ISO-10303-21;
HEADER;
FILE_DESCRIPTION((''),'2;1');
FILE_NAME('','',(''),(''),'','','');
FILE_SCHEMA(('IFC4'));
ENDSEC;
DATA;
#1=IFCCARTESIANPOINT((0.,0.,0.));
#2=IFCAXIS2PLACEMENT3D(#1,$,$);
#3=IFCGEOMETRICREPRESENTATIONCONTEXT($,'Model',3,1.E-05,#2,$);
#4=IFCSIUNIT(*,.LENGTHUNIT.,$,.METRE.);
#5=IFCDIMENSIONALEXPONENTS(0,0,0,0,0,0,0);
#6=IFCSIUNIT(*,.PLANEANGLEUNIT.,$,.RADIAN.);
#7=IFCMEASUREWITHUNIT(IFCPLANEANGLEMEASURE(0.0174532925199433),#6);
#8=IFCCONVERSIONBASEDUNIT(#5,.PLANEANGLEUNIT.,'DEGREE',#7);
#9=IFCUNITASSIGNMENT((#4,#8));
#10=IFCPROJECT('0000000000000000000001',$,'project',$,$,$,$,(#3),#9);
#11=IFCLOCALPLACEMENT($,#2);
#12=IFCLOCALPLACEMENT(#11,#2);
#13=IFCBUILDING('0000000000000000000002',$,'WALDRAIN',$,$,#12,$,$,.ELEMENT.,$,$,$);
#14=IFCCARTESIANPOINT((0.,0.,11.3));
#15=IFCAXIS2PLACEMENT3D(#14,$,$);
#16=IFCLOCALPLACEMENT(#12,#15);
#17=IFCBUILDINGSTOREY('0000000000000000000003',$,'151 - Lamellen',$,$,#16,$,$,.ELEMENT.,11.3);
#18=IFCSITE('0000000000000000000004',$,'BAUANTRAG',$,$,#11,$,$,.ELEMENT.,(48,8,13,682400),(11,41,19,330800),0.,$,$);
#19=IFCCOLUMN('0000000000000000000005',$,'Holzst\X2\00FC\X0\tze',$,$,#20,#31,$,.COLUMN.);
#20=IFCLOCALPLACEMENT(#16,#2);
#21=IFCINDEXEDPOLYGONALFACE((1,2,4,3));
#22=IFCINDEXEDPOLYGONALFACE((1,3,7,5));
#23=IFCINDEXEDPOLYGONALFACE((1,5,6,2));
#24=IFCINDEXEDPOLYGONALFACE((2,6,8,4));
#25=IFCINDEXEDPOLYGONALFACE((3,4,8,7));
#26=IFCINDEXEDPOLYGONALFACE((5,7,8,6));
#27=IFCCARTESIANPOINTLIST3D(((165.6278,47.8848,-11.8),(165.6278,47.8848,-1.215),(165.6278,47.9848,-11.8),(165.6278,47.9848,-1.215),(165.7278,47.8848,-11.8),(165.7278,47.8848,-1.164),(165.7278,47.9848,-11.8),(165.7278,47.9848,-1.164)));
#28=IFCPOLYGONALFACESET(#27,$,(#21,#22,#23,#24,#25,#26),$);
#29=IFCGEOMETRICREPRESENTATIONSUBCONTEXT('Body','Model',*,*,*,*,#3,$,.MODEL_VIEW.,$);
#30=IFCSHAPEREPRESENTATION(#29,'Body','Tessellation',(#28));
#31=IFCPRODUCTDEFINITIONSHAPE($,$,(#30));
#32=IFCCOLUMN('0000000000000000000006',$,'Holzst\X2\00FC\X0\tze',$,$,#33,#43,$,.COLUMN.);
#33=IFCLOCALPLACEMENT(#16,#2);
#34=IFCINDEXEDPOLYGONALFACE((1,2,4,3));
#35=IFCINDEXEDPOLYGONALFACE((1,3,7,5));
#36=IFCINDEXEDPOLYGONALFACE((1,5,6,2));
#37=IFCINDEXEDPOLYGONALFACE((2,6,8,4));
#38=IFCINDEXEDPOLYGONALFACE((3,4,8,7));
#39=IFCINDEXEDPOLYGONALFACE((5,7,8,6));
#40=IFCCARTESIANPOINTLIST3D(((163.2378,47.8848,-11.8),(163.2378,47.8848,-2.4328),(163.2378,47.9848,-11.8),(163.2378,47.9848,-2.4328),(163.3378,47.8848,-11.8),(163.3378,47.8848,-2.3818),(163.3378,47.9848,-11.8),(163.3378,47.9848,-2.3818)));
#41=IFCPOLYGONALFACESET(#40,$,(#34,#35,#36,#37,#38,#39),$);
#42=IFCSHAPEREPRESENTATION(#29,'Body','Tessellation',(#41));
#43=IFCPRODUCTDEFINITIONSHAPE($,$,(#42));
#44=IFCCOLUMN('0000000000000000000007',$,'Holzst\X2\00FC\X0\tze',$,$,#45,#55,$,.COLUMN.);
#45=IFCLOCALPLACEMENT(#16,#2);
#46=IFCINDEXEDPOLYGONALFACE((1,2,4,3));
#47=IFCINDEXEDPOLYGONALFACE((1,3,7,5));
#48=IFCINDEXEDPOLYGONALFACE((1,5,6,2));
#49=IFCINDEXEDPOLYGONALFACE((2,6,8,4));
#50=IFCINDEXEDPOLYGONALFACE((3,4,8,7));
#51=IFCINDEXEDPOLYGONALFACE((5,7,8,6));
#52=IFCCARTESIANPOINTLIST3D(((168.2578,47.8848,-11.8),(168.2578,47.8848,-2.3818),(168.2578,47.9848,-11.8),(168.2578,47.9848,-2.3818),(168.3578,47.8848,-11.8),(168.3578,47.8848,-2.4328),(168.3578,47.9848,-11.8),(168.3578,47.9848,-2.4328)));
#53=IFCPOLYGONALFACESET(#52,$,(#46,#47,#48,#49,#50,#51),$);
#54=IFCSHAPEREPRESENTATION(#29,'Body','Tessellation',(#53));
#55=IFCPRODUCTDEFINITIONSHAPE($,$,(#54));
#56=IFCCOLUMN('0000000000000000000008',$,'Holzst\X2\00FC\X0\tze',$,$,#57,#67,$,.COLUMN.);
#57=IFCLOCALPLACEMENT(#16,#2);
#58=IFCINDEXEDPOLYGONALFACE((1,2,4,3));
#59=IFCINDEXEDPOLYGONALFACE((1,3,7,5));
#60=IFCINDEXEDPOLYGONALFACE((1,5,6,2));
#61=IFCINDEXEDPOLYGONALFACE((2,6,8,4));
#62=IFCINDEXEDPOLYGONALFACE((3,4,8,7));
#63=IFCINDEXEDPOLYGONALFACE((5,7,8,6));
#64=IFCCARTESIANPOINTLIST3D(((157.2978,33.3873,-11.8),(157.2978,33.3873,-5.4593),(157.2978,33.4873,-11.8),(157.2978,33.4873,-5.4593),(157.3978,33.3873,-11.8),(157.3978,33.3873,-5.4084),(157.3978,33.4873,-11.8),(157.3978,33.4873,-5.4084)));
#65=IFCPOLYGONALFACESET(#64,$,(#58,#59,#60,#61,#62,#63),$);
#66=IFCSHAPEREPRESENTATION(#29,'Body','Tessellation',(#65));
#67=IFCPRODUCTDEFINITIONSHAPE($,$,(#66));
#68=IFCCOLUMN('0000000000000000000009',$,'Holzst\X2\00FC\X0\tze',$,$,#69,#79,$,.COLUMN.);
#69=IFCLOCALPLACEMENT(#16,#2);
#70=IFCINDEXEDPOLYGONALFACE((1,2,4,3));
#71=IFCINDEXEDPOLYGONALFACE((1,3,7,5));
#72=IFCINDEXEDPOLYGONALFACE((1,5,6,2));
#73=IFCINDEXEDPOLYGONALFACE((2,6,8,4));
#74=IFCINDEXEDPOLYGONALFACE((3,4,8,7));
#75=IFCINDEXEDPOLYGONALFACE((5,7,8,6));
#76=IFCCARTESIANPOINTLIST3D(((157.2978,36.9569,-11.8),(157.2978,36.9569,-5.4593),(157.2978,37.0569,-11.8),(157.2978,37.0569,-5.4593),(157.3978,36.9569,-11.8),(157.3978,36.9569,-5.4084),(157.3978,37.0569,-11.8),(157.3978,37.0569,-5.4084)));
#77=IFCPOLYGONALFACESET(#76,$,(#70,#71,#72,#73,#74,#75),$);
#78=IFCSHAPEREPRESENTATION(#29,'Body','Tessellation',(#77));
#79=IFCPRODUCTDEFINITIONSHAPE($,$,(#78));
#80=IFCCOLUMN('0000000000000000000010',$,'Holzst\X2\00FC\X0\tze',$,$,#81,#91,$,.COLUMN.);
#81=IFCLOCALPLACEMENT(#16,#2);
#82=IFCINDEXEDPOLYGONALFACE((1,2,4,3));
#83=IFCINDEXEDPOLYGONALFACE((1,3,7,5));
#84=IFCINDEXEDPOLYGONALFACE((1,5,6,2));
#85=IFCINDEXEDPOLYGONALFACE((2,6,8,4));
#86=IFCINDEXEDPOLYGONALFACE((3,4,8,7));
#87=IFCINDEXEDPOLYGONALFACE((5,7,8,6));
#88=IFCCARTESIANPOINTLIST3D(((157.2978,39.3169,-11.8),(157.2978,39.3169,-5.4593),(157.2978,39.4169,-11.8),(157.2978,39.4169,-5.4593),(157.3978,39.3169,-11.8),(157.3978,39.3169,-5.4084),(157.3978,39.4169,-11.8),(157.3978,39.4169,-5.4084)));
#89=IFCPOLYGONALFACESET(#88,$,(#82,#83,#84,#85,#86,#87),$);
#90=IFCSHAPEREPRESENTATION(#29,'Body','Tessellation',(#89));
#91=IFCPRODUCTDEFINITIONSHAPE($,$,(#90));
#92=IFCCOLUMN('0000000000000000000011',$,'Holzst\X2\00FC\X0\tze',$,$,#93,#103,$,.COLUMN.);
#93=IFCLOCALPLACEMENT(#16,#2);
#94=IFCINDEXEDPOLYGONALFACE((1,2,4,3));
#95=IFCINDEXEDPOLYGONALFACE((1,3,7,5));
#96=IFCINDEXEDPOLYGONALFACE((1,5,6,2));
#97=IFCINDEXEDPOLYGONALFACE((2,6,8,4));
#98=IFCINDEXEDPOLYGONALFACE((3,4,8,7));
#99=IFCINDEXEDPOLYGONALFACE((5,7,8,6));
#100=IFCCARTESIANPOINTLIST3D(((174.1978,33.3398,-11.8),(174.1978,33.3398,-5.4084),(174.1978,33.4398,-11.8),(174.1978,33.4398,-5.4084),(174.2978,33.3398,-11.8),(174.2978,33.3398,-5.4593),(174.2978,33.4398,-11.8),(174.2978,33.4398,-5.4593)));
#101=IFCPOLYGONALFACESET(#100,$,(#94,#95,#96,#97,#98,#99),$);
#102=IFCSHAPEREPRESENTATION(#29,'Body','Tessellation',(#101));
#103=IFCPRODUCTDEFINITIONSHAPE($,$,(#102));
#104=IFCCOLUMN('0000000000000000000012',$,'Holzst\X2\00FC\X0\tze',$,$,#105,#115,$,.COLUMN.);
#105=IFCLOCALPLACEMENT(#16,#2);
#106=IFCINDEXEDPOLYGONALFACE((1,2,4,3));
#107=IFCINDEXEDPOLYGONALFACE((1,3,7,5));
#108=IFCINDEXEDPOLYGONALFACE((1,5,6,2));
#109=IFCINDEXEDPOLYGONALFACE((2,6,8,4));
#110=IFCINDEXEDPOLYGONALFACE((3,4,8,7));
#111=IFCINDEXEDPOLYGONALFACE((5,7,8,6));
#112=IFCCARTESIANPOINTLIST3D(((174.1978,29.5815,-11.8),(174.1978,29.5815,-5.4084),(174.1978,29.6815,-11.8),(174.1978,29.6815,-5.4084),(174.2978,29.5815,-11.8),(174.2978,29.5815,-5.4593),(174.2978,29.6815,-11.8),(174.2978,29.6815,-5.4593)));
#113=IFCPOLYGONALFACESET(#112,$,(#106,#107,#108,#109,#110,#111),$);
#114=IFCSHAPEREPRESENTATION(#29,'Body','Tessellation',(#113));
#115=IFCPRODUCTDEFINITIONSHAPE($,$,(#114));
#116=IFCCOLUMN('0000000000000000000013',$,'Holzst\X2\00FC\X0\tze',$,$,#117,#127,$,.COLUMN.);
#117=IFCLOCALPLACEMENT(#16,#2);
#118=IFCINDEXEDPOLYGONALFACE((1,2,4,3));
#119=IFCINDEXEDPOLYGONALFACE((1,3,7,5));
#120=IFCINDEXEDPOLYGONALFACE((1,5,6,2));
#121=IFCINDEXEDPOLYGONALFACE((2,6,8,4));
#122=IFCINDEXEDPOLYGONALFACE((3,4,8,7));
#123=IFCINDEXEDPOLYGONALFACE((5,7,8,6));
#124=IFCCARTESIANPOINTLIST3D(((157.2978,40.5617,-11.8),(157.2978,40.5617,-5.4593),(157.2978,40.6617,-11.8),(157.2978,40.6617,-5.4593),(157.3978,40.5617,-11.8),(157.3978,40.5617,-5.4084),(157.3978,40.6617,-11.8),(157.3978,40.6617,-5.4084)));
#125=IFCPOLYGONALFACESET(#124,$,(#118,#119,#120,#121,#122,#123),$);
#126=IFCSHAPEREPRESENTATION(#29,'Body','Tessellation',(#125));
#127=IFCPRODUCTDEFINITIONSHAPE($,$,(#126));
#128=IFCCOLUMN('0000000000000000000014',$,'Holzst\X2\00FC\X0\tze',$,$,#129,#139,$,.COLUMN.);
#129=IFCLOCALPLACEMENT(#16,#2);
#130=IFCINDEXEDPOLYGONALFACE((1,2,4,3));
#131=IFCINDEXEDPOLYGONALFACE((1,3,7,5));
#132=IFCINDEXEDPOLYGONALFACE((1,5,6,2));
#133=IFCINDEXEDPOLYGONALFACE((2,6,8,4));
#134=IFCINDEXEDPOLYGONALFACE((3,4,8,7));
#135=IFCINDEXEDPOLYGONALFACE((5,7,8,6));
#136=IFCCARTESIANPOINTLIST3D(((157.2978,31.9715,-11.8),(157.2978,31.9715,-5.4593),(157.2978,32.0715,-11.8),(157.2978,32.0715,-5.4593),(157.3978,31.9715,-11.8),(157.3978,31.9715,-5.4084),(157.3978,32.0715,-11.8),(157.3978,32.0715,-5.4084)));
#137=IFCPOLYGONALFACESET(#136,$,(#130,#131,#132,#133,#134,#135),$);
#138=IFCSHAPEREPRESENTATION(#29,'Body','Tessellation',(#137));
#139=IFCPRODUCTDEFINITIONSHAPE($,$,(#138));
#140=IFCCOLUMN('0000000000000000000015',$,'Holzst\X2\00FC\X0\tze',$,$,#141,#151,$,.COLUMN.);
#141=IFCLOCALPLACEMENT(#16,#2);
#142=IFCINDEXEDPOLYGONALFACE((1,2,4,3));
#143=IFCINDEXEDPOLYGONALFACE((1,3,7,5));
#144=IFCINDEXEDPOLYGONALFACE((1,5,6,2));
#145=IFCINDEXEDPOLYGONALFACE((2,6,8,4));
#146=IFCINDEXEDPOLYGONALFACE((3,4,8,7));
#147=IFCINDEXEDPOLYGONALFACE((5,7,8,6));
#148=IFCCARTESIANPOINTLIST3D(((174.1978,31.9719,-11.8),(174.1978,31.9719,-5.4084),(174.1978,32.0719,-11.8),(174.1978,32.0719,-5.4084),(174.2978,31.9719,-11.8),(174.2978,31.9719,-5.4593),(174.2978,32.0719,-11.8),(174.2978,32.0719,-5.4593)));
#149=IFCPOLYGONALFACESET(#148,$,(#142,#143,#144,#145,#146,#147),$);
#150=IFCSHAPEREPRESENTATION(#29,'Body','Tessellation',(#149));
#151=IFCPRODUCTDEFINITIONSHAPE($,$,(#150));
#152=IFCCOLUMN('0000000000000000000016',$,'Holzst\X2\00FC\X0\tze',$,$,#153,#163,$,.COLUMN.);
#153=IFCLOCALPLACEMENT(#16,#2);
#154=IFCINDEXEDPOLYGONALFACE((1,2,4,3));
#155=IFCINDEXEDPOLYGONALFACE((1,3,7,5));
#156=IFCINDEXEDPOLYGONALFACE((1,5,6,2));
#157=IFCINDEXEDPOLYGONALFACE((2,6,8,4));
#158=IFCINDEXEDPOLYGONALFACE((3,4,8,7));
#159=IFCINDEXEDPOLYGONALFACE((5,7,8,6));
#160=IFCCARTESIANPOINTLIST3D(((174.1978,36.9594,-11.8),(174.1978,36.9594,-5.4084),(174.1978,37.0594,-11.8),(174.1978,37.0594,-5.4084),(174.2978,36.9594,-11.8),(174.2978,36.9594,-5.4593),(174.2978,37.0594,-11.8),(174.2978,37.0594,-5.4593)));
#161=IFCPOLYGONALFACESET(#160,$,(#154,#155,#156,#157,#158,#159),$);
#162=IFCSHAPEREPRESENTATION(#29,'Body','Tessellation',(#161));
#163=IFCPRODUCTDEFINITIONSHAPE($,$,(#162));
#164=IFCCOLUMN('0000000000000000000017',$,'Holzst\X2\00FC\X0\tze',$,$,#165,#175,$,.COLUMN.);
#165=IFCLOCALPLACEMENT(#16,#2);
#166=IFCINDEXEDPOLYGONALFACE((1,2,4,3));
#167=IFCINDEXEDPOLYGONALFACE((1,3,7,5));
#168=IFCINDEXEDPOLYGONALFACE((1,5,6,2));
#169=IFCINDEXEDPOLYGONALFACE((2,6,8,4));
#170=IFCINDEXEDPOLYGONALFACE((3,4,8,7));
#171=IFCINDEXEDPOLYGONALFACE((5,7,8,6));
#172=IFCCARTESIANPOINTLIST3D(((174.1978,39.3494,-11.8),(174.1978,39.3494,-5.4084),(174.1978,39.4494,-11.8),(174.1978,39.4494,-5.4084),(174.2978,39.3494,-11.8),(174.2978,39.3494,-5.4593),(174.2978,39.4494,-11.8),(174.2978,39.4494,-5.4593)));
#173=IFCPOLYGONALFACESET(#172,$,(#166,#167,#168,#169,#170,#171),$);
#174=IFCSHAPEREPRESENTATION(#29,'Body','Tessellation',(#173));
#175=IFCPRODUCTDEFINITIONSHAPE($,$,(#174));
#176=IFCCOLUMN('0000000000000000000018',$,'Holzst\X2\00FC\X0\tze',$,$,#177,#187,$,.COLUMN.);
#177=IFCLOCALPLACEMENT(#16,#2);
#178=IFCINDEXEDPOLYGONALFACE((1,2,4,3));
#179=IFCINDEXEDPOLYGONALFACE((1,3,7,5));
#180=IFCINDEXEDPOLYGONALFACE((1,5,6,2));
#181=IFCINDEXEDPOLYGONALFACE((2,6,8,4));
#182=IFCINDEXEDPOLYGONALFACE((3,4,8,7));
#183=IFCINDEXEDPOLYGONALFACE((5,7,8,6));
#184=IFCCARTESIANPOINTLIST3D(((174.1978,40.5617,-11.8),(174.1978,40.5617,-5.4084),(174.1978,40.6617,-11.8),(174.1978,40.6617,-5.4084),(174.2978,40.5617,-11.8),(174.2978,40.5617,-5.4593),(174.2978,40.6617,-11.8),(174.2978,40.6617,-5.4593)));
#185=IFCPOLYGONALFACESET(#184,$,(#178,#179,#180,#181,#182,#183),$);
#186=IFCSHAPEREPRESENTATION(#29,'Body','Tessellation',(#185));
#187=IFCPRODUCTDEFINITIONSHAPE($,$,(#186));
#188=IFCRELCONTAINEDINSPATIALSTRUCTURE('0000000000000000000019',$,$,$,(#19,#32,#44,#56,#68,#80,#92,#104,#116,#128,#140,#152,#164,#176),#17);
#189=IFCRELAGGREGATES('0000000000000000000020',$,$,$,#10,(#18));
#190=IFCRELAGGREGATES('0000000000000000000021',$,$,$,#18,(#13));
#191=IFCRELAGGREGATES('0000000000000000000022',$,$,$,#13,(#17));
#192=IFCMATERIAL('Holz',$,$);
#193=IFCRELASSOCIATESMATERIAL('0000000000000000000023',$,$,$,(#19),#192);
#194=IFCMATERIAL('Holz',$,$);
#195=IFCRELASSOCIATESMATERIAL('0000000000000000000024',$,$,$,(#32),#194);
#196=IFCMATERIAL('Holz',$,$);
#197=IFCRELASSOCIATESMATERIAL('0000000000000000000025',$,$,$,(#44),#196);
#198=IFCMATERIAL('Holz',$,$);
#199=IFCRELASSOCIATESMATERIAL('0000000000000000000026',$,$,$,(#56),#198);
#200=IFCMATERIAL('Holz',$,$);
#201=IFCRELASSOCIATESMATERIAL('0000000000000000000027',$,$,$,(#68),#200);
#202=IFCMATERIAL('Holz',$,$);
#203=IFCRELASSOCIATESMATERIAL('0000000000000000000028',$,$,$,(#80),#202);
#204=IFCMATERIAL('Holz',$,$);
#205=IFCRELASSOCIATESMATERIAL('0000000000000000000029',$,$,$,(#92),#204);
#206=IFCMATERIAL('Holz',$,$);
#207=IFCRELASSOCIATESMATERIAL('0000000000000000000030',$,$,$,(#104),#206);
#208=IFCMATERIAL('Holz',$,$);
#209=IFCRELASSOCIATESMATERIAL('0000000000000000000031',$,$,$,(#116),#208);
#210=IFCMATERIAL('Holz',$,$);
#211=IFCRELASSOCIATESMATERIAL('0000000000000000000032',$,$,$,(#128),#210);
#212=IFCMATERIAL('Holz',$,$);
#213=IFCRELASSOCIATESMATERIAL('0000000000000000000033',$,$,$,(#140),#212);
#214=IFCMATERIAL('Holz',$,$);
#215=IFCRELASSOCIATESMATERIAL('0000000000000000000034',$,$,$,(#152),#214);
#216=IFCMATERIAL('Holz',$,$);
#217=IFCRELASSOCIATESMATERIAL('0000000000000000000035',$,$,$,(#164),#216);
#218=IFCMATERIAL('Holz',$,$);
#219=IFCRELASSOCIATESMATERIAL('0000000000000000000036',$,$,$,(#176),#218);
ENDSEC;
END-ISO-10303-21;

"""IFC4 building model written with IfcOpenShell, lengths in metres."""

from ifc_helpers import new_model, entity, si_unit, converted_unit, frame, frame_2d, origin, origin_with_axes, place, context, subcontext, project, spatial, rectangle, extrude, clip, halfspace, material, element, save


model = new_model("IFC4")

# Units and contexts
model_context = context("Model", 3, precision=1e-05, world=origin())
body_context = subcontext(model_context, "Body", "Model", "MODEL_VIEW")
ifc_project = project(units=[si_unit("LENGTHUNIT", "METRE"), converted_unit("PLANEANGLEUNIT", "DEGREE", entity("IfcPlaneAngleMeasure", 0.0174532925199433), si_unit("PLANEANGLEUNIT", "RADIAN"), dimensions=[0, 0, 0, 0, 0, 0, 0])], contexts=[model_context])

# Site, building, storey
site_placement = place(None, origin())
site = spatial("IfcSite", under=ifc_project, at=site_placement, Name="BAUANTRAG", CompositionType="ELEMENT", RefLatitude=(48, 8, 13, 682400), RefLongitude=(11, 41, 19, 330800), RefElevation=0.0)
building_placement = place(site_placement, origin())
building = spatial("IfcBuilding", under=site, at=building_placement, Name="WALDRAIN", CompositionType="ELEMENT")
storey_placement = place(building_placement, frame((0.0, 0.0, 11.3)))
storey = spatial("IfcBuildingStorey", under=building, at=storey_placement, Name="151 - Lamellen", CompositionType="ELEMENT", Elevation=11.3)

# Columns
ifc_material_1 = material(Name="Holz")
column_1_placement = place(storey_placement, frame((165.7278, 47.8848, -11.8)))
element("IfcColumn", 1, at=column_1_placement, inside=storey, material=ifc_material_1, Name="Holzstütze", PredefinedType="COLUMN", context=body_context, shape_type="Clipping", body=[
    clip(extrude(rectangle(XDim=0.1, YDim=0.1, at=frame_2d((-0.05, 0.05), x_axis=(0.0, 1.0))), origin_with_axes(), (0.0, 0.0, 1.0), 10.636), halfspace(frame((-0.05, 0.05, 10.6105), z_axis=(0.45399, 0.0, -0.891007), x_axis=(0.0, 1.0, 0.0)), True)),
])
ifc_material_2 = material(Name="Holz")
column_2_placement = place(storey_placement, frame((163.3378, 47.8848, -11.8)))
element("IfcColumn", 2, at=column_2_placement, inside=storey, material=ifc_material_2, Name="Holzstütze", PredefinedType="COLUMN", context=body_context, shape_type="Clipping", body=[
    clip(extrude(rectangle(XDim=0.1, YDim=0.1, at=frame_2d((-0.05, 0.05), x_axis=(0.0, 1.0))), origin_with_axes(), (0.0, 0.0, 1.0), 9.4182), halfspace(frame((-0.05, 0.05, 9.3927), z_axis=(0.45399, 0.0, -0.891007), x_axis=(0.0, 1.0, 0.0)), True)),
])
ifc_material_3 = material(Name="Holz")
column_3_placement = place(storey_placement, frame((168.3578, 47.8848, -11.8)))
element("IfcColumn", 3, at=column_3_placement, inside=storey, material=ifc_material_3, Name="Holzstütze", PredefinedType="COLUMN", context=body_context, shape_type="Clipping", body=[
    clip(extrude(rectangle(XDim=0.1, YDim=0.1, at=frame_2d((-0.05, 0.05), x_axis=(0.0, 1.0))), origin_with_axes(), (0.0, 0.0, 1.0), 9.4182), halfspace(frame((-0.05, 0.05, 9.3927), z_axis=(-0.45399, 0.0, -0.891007), x_axis=(0.0, 1.0, 0.0)), True)),
])
ifc_material_4 = material(Name="Holz")
column_4_placement = place(storey_placement, frame((157.3978, 33.3873, -11.8)))
element("IfcColumn", 4, at=column_4_placement, inside=storey, material=ifc_material_4, Name="Holzstütze", PredefinedType="COLUMN", context=body_context, shape_type="Clipping", body=[
    clip(extrude(rectangle(XDim=0.1, YDim=0.1, at=frame_2d((-0.05, 0.05), x_axis=(0.0, 1.0))), origin_with_axes(), (0.0, 0.0, 1.0), 6.3916), halfspace(frame((-0.05, 0.05, 6.3661), z_axis=(0.45399, 0.0, -0.891007), x_axis=(-0.891007, 0.0, -0.45399)), True)),
])
ifc_material_5 = material(Name="Holz")
column_5_placement = place(storey_placement, frame((157.3978, 36.9569, -11.8)))
element("IfcColumn", 5, at=column_5_placement, inside=storey, material=ifc_material_5, Name="Holzstütze", PredefinedType="COLUMN", context=body_context, shape_type="Clipping", body=[
    clip(extrude(rectangle(XDim=0.1, YDim=0.1, at=frame_2d((-0.05, 0.05), x_axis=(0.0, 1.0))), origin_with_axes(), (0.0, 0.0, 1.0), 6.3916), halfspace(frame((-0.05, 0.05, 6.3661), z_axis=(0.45399, 0.0, -0.891007), x_axis=(-0.891007, 0.0, -0.45399)), True)),
])
ifc_material_6 = material(Name="Holz")
column_6_placement = place(storey_placement, frame((157.3978, 39.3169, -11.8)))
element("IfcColumn", 6, at=column_6_placement, inside=storey, material=ifc_material_6, Name="Holzstütze", PredefinedType="COLUMN", context=body_context, shape_type="Clipping", body=[
    clip(extrude(rectangle(XDim=0.1, YDim=0.1, at=frame_2d((-0.05, 0.05), x_axis=(0.0, 1.0))), origin_with_axes(), (0.0, 0.0, 1.0), 6.3916), halfspace(frame((-0.05, 0.05, 6.3661), z_axis=(0.45399, 0.0, -0.891007), x_axis=(-0.891007, 0.0, -0.45399)), True)),
])
ifc_material_7 = material(Name="Holz")
column_7_placement = place(storey_placement, frame((174.2978, 33.3398, -11.8)))
element("IfcColumn", 7, at=column_7_placement, inside=storey, material=ifc_material_7, Name="Holzstütze", PredefinedType="COLUMN", context=body_context, shape_type="Clipping", body=[
    clip(extrude(rectangle(XDim=0.1, YDim=0.1, at=frame_2d((-0.05, 0.05), x_axis=(0.0, 1.0))), origin_with_axes(), (0.0, 0.0, 1.0), 6.3916), halfspace(frame((-0.05, 0.05, 6.3661), z_axis=(-0.45399, 0.0, -0.891007), x_axis=(0.891007, 0.0, -0.45399)), True)),
])
ifc_material_8 = material(Name="Holz")
column_8_placement = place(storey_placement, frame((174.2978, 29.5815, -11.8)))
element("IfcColumn", 8, at=column_8_placement, inside=storey, material=ifc_material_8, Name="Holzstütze", PredefinedType="COLUMN", context=body_context, shape_type="Clipping", body=[
    clip(extrude(rectangle(XDim=0.1, YDim=0.1, at=frame_2d((-0.05, 0.05), x_axis=(0.0, 1.0))), origin_with_axes(), (0.0, 0.0, 1.0), 6.3916), halfspace(frame((-0.05, 0.05, 6.3661), z_axis=(-0.45399, 0.0, -0.891007), x_axis=(0.891007, 0.0, -0.45399)), True)),
])
ifc_material_9 = material(Name="Holz")
column_9_placement = place(storey_placement, frame((157.3978, 40.5617, -11.8)))
element("IfcColumn", 9, at=column_9_placement, inside=storey, material=ifc_material_9, Name="Holzstütze", PredefinedType="COLUMN", context=body_context, shape_type="Clipping", body=[
    clip(extrude(rectangle(XDim=0.1, YDim=0.1, at=frame_2d((-0.05, 0.05), x_axis=(0.0, 1.0))), origin_with_axes(), (0.0, 0.0, 1.0), 6.3916), halfspace(frame((-0.05, 0.05, 6.3661), z_axis=(0.45399, 0.0, -0.891007), x_axis=(-0.891007, 0.0, -0.45399)), True)),
])
ifc_material_10 = material(Name="Holz")
column_10_placement = place(storey_placement, frame((157.3978, 31.9715, -11.8)))
element("IfcColumn", 10, at=column_10_placement, inside=storey, material=ifc_material_10, Name="Holzstütze", PredefinedType="COLUMN", context=body_context, shape_type="Clipping", body=[
    clip(extrude(rectangle(XDim=0.1, YDim=0.1, at=frame_2d((-0.05, 0.05), x_axis=(0.0, 1.0))), origin_with_axes(), (0.0, 0.0, 1.0), 6.3916), halfspace(frame((-0.05, 0.05, 6.3661), z_axis=(0.45399, 0.0, -0.891007), x_axis=(-0.891007, 0.0, -0.45399)), True)),
])
ifc_material_11 = material(Name="Holz")
column_11_placement = place(storey_placement, frame((174.2978, 31.9719, -11.8)))
element("IfcColumn", 11, at=column_11_placement, inside=storey, material=ifc_material_11, Name="Holzstütze", PredefinedType="COLUMN", context=body_context, shape_type="Clipping", body=[
    clip(extrude(rectangle(XDim=0.1, YDim=0.1, at=frame_2d((-0.05, 0.05), x_axis=(0.0, 1.0))), origin_with_axes(), (0.0, 0.0, 1.0), 6.3916), halfspace(frame((-0.05, 0.05, 6.3661), z_axis=(-0.45399, 0.0, -0.891007), x_axis=(0.891007, 0.0, -0.45399)), True)),
])
ifc_material_12 = material(Name="Holz")
column_12_placement = place(storey_placement, frame((174.2978, 36.9594, -11.8)))
element("IfcColumn", 12, at=column_12_placement, inside=storey, material=ifc_material_12, Name="Holzstütze", PredefinedType="COLUMN", context=body_context, shape_type="Clipping", body=[
    clip(extrude(rectangle(XDim=0.1, YDim=0.1, at=frame_2d((-0.05, 0.05), x_axis=(0.0, 1.0))), origin_with_axes(), (0.0, 0.0, 1.0), 6.3916), halfspace(frame((-0.05, 0.05, 6.3661), z_axis=(-0.45399, 0.0, -0.891007), x_axis=(0.891007, 0.0, -0.45399)), True)),
])
ifc_material_13 = material(Name="Holz")
column_13_placement = place(storey_placement, frame((174.2978, 39.3494, -11.8)))
element("IfcColumn", 13, at=column_13_placement, inside=storey, material=ifc_material_13, Name="Holzstütze", PredefinedType="COLUMN", context=body_context, shape_type="Clipping", body=[
    clip(extrude(rectangle(XDim=0.1, YDim=0.1, at=frame_2d((-0.05, 0.05), x_axis=(0.0, 1.0))), origin_with_axes(), (0.0, 0.0, 1.0), 6.3916), halfspace(frame((-0.05, 0.05, 6.3661), z_axis=(-0.45399, 0.0, -0.891007), x_axis=(0.891007, 0.0, -0.45399)), True)),
])
ifc_material_14 = material(Name="Holz")
column_14_placement = place(storey_placement, frame((174.2978, 40.5617, -11.8)))
element("IfcColumn", 14, at=column_14_placement, inside=storey, material=ifc_material_14, Name="Holzstütze", PredefinedType="COLUMN", context=body_context, shape_type="Clipping", body=[
    clip(extrude(rectangle(XDim=0.1, YDim=0.1, at=frame_2d((-0.05, 0.05), x_axis=(0.0, 1.0))), origin_with_axes(), (0.0, 0.0, 1.0), 6.3916), halfspace(frame((-0.05, 0.05, 6.3661), z_axis=(-0.45399, 0.0, -0.891007), x_axis=(0.891007, 0.0, -0.45399)), True)),
])

save(model, "model.ifc")
